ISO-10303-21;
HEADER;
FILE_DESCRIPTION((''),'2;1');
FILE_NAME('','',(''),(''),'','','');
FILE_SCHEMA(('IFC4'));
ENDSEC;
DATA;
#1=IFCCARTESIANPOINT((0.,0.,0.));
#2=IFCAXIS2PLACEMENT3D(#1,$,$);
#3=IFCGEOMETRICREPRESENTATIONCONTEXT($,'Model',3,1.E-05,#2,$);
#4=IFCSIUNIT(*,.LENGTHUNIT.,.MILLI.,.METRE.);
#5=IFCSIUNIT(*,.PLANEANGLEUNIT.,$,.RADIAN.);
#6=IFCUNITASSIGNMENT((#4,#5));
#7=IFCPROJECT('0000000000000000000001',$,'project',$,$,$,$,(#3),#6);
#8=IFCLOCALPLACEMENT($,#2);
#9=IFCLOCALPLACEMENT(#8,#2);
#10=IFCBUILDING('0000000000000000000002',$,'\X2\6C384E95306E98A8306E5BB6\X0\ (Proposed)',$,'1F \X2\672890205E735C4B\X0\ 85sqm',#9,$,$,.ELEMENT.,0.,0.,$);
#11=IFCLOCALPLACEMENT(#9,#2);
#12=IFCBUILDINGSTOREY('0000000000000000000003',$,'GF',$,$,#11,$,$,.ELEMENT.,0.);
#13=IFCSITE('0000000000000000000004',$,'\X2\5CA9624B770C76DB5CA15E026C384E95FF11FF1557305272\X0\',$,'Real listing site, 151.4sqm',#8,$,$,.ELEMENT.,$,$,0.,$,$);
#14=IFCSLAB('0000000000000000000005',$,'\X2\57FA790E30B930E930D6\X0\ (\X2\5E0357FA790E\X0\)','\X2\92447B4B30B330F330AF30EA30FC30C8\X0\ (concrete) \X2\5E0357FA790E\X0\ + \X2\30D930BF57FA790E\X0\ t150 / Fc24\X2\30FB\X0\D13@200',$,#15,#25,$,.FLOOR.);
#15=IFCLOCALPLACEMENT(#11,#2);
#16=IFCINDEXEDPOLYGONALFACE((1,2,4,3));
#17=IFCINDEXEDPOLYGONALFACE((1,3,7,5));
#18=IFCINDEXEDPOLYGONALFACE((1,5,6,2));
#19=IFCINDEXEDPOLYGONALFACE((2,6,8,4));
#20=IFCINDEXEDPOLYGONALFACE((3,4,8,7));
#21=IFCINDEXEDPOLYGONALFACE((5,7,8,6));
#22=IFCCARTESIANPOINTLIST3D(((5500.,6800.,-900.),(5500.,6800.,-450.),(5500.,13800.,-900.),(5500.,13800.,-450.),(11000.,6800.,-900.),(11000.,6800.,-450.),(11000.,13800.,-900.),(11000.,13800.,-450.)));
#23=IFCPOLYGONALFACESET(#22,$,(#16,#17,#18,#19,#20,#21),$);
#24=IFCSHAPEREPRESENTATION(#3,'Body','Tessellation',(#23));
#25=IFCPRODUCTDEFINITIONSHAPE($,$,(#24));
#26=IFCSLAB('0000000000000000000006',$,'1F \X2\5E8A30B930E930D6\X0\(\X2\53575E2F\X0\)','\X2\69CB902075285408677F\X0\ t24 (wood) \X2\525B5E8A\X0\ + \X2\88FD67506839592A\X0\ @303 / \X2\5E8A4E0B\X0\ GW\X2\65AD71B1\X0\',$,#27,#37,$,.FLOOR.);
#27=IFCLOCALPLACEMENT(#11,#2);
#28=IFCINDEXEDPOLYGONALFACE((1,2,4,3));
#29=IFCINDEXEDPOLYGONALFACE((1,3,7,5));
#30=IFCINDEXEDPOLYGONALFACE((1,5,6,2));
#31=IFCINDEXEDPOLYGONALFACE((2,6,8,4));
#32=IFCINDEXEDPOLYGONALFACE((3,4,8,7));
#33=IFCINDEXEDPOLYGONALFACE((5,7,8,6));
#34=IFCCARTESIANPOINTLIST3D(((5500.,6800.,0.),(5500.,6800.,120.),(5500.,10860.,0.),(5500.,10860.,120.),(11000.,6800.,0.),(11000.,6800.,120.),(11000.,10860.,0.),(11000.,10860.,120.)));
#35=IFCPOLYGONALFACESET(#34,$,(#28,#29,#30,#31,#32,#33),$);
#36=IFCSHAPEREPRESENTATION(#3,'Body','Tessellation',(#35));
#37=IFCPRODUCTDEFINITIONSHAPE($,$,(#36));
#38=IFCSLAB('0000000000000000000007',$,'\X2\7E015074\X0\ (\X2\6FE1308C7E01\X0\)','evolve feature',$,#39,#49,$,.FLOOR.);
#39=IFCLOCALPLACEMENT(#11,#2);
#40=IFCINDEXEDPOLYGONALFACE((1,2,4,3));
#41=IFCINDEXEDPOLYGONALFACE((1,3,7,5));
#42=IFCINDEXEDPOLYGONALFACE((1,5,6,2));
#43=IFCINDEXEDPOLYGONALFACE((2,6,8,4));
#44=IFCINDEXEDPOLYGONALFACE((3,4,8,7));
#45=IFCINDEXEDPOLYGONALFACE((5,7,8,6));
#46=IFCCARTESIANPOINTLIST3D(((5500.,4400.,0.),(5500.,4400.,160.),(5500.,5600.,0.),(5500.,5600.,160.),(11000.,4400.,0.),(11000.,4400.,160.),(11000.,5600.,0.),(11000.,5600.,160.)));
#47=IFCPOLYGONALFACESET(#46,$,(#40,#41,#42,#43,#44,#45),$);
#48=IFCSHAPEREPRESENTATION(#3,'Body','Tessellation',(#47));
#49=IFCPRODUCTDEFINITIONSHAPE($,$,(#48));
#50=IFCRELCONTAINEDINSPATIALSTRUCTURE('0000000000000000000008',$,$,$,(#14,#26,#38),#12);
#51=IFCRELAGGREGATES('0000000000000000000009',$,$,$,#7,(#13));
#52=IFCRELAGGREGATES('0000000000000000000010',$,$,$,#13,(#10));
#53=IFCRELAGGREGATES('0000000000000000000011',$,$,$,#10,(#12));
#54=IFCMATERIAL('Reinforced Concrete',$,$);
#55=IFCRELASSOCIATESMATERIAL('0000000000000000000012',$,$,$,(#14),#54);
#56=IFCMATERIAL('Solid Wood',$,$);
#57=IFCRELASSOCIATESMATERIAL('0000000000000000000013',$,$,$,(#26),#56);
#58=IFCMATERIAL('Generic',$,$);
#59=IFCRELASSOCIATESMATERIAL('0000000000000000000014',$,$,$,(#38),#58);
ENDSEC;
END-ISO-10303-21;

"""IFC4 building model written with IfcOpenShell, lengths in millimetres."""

from ifc_helpers import new_model, si_unit, frame, frame_2d, origin, place, context, project, spatial, rectangle, extrude, material, element, save


model = new_model("IFC4")

# Units and contexts
model_context = context("Model", 3, precision=1e-05, world=origin())
ifc_project = project(units=[si_unit("LENGTHUNIT", "METRE", prefix="MILLI"), si_unit("PLANEANGLEUNIT", "RADIAN")], contexts=[model_context])

# Site, building, storey
site_placement = place(None, origin())
site = spatial("IfcSite", under=ifc_project, at=site_placement, Name="岩手県盛岡市永井１５地割", ObjectType="Real listing site, 151.4sqm", CompositionType="ELEMENT", RefElevation=0.0)
building_placement = place(site_placement, origin())
building = spatial("IfcBuilding", under=site, at=building_placement, Name="永井の風の家 (Proposed)", ObjectType="1F 木造平屋 85sqm", CompositionType="ELEMENT", ElevationOfRefHeight=0.0, ElevationOfTerrain=0.0)
storey_placement = place(building_placement, origin())
storey = spatial("IfcBuildingStorey", under=building, at=storey_placement, Name="GF", CompositionType="ELEMENT", Elevation=0.0)

# Slabs
ifc_material_1 = material(Name="Reinforced Concrete")
slab_1_placement = place(storey_placement, frame((2750.0, 3400.0, -450.0)))
element("IfcSlab", 1, at=slab_1_placement, inside=storey, material=ifc_material_1, Name="基礎スラブ (布基礎)", Description="鉄筋コンクリート (concrete) 布基礎 + ベタ基礎 t150 / Fc24・D13@200", PredefinedType="FLOOR", context=model_context, shape_type="SweptSolid", body=[
    extrude(rectangle(XDim=5500.0, YDim=7000.0, at=frame_2d((2750.0, 3500.0))), frame((2750.0, 3400.0, -450.0)), (0.0, 0.0, 1.0), 450.0),
])
ifc_material_2 = material(Name="Solid Wood")
slab_2_placement = place(storey_placement, frame((2750.0, 3400.0, 0.0)))
element("IfcSlab", 2, at=slab_2_placement, inside=storey, material=ifc_material_2, Name="1F 床スラブ(南帯)", Description="構造用合板 t24 (wood) 剛床 + 製材根太 @303 / 床下 GW断熱", PredefinedType="FLOOR", context=model_context, shape_type="SweptSolid", body=[
    extrude(rectangle(XDim=5500.0, YDim=4060.0, at=frame_2d((2750.0, 2030.0))), frame((2750.0, 3400.0, 0.0)), (0.0, 0.0, 1.0), 120.0),
])
ifc_material_3 = material(Name="Generic")
slab_3_placement = place(storey_placement, frame((2750.0, 2200.0, 0.0)))
element("IfcSlab", 3, at=slab_3_placement, inside=storey, material=ifc_material_3, Name="縁側 (濡れ縁)", Description="evolve feature", PredefinedType="FLOOR", context=model_context, shape_type="SweptSolid", body=[
    extrude(rectangle(XDim=5500.0, YDim=1200.0, at=frame_2d((2750.0, 600.0))), frame((2750.0, 2200.0, 0.0)), (0.0, 0.0, 1.0), 160.0),
])

save(model, "model.ifc")
